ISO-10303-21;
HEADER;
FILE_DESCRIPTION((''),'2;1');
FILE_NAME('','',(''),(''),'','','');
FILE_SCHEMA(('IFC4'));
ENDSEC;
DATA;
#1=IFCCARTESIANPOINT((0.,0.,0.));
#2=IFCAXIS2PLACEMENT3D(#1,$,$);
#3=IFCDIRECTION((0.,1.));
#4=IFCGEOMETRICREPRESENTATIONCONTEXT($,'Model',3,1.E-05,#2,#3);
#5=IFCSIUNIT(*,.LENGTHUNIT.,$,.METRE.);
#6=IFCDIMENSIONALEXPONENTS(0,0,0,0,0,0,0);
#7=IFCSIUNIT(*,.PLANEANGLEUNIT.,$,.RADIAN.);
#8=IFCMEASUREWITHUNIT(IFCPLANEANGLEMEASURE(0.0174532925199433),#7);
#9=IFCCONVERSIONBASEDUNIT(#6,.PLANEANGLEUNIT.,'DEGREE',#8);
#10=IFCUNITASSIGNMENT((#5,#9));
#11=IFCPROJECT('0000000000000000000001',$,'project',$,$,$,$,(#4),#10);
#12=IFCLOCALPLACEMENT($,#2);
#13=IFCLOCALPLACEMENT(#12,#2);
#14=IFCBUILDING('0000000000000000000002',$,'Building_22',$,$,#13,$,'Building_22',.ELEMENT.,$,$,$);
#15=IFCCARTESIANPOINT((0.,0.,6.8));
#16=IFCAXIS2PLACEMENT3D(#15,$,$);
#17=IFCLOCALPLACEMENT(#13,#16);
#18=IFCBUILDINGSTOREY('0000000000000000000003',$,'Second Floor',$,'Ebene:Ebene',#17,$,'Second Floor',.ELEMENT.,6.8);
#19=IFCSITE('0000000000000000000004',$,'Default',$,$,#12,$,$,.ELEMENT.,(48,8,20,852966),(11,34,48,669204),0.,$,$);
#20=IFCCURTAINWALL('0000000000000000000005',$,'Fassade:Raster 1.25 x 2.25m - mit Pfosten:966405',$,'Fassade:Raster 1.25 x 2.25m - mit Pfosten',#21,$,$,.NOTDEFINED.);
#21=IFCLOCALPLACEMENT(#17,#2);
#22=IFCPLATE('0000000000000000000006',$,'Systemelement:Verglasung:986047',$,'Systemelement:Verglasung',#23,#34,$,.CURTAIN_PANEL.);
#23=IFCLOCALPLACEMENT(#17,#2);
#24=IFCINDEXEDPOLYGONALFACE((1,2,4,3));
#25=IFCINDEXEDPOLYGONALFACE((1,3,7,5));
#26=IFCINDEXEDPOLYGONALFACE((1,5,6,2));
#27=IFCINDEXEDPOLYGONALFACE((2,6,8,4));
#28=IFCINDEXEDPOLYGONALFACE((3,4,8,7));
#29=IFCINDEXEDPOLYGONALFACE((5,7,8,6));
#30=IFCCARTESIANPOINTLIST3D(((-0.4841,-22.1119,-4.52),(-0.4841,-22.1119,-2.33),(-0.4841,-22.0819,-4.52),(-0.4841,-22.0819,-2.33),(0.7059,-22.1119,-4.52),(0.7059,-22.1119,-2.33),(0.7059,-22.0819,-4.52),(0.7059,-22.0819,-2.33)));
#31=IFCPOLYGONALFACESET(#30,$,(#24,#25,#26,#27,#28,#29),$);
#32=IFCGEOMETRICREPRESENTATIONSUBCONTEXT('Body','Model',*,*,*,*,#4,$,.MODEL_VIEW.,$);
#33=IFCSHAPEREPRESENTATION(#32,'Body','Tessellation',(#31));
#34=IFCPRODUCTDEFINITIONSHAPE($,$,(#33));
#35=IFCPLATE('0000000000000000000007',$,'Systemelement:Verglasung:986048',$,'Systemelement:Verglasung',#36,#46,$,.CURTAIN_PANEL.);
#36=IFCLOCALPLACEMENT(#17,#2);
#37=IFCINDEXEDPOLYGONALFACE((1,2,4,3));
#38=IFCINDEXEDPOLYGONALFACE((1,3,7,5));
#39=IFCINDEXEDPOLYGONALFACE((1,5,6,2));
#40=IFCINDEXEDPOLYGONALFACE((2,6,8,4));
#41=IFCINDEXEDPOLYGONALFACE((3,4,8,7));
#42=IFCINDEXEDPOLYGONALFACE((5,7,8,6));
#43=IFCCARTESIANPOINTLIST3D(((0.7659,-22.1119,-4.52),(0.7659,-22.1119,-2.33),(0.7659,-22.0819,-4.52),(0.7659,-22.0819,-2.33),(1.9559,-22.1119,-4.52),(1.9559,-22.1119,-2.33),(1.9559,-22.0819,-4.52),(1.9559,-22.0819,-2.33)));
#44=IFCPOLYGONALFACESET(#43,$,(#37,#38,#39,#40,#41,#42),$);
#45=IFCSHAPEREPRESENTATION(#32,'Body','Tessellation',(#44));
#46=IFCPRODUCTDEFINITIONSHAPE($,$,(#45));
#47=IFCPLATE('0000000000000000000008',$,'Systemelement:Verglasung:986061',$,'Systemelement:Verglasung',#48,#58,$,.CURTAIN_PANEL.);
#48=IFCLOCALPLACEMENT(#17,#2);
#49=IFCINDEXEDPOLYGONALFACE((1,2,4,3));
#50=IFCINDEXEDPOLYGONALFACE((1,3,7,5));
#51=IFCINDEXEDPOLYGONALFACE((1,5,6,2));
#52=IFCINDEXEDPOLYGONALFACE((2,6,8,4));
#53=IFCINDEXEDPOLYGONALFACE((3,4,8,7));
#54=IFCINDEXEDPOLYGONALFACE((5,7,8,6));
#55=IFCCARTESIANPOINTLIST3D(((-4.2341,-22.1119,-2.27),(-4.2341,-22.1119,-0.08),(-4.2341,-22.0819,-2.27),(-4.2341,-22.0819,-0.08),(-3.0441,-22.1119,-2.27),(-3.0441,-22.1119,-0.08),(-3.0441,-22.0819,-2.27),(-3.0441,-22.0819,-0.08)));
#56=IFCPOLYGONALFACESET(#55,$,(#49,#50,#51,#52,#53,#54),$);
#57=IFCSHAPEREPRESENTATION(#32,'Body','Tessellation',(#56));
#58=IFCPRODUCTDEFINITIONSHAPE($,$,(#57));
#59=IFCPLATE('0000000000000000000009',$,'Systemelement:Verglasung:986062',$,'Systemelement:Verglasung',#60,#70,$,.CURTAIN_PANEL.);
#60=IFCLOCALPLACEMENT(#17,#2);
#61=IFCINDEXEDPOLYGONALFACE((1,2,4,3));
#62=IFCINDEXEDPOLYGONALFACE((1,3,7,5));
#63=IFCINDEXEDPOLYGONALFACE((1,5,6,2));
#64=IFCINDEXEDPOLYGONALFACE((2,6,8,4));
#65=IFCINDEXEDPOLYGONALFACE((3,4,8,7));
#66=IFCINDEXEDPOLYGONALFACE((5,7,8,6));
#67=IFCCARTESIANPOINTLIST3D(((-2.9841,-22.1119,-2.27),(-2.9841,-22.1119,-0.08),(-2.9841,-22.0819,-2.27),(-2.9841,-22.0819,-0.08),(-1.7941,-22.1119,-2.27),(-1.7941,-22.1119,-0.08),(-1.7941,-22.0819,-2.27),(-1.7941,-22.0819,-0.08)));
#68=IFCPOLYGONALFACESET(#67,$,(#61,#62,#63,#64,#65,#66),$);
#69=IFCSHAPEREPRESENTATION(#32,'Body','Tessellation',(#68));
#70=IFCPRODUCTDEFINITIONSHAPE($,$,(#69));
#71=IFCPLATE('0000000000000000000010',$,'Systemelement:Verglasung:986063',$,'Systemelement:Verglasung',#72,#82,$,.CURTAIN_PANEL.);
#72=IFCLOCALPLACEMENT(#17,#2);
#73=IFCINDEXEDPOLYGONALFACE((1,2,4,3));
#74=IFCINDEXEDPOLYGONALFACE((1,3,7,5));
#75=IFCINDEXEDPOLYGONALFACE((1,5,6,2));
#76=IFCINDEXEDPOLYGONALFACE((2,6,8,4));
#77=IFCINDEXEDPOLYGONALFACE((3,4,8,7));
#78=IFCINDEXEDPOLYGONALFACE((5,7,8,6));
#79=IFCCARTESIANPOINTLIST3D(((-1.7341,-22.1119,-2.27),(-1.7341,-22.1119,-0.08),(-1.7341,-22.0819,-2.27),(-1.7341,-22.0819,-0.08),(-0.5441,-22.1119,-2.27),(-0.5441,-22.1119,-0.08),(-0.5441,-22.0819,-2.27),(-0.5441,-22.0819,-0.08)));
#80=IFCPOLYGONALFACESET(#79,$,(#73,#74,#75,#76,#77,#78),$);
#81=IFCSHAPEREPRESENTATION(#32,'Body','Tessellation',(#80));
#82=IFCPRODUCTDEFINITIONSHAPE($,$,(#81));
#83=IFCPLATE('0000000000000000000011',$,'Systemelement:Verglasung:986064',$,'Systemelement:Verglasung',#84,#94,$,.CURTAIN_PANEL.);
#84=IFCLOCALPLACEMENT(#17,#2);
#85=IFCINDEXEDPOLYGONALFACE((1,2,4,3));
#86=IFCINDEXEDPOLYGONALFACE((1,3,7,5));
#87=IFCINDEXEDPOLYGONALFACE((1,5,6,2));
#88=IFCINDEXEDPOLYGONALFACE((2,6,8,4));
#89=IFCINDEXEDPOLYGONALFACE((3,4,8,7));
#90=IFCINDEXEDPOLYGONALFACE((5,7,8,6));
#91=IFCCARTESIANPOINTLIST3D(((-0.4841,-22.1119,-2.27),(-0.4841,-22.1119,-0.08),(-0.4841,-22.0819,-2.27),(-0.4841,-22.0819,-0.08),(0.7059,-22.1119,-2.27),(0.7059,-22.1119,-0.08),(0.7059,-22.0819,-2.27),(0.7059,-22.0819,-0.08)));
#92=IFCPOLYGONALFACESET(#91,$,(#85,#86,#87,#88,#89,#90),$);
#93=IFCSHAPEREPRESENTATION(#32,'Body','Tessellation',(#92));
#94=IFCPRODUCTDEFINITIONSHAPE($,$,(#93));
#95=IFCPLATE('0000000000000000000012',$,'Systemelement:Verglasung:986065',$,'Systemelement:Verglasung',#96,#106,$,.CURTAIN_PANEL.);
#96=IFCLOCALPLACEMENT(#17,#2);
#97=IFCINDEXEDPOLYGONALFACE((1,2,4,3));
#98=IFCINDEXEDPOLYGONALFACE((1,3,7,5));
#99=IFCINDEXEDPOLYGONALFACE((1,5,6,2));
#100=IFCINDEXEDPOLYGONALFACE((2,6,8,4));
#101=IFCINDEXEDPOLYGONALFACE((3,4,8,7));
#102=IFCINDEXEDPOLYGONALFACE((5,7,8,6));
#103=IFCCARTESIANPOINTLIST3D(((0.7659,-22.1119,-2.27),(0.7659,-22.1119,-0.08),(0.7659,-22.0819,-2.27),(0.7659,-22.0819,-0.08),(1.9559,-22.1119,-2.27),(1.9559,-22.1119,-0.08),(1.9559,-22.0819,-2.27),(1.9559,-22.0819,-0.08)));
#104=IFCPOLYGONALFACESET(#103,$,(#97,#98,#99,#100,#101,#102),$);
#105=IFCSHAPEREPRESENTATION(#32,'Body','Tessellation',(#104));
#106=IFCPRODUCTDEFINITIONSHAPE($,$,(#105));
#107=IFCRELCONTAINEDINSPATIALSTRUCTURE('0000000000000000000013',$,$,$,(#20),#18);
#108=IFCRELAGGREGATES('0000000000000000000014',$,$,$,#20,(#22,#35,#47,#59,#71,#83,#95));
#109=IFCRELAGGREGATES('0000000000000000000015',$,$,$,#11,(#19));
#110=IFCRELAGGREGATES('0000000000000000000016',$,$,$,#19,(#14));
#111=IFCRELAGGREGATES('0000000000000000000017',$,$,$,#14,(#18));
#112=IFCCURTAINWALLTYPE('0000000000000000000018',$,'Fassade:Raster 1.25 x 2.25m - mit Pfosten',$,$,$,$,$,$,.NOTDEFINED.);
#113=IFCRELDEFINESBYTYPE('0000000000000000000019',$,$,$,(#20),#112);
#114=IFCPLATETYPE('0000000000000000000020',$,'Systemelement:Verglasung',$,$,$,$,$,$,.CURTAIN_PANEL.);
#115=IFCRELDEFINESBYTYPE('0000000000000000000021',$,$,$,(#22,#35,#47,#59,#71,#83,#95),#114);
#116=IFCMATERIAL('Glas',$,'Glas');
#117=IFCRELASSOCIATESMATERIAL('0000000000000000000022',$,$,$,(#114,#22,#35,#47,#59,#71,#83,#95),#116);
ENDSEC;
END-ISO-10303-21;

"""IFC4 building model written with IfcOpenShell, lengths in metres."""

from ifc_helpers import new_model, entity, si_unit, converted_unit, direction, frame, origin, place, context, subcontext, project, spatial, indexed_curve, outline, extrude, source, transform, mapped, material, type_object, type_shapes, element, aggregate, save


model = new_model("IFC4")

# Units and contexts
model_context = context("Model", 3, precision=1e-05, world=origin(), true_north=direction((0.0, 1.0)))
body_context = subcontext(model_context, "Body", "Model", "MODEL_VIEW")
ifc_project = project(units=[si_unit("LENGTHUNIT", "METRE"), converted_unit("PLANEANGLEUNIT", "DEGREE", entity("IfcPlaneAngleMeasure", 0.0174532925199433), si_unit("PLANEANGLEUNIT", "RADIAN"), dimensions=[0, 0, 0, 0, 0, 0, 0])], contexts=[model_context])

# Site, building, storey
site_placement = place(None, origin())
site = spatial("IfcSite", under=ifc_project, at=site_placement, Name="Default", CompositionType="ELEMENT", RefLatitude=(48, 8, 20, 852966), RefLongitude=(11, 34, 48, 669204), RefElevation=0.0)
building_placement = place(site_placement, origin())
building = spatial("IfcBuilding", under=site, at=building_placement, Name="Building_22", LongName="Building_22", CompositionType="ELEMENT")
storey_placement = place(building_placement, frame((0.0, 0.0, 6.8)))
storey = spatial("IfcBuildingStorey", under=building, at=storey_placement, Name="Second Floor", ObjectType="Ebene:Ebene", LongName="Second Floor", CompositionType="ELEMENT", Elevation=6.8)

# Curtain wall, plates
curtain_wall_type = type_object("IfcCurtainWallType", Name="Fassade:Raster 1.25 x 2.25m - mit Pfosten", PredefinedType="NOTDEFINED")
curtain_wall_placement = place(storey_placement, frame((0.0, 0.0, -6.8)))
curtain_wall = element("IfcCurtainWall", 1, at=curtain_wall_placement, inside=storey, type_object=curtain_wall_type, Name="Fassade:Raster 1.25 x 2.25m - mit Pfosten:966405", ObjectType="Fassade:Raster 1.25 x 2.25m - mit Pfosten", PredefinedType="NOTDEFINED")
ifc_material_1 = material(Name="Glas", Category="Glas")
plate_type_1 = type_object("IfcPlateType", Name="Systemelement:Verglasung", PredefinedType="CURTAIN_PANEL", material=ifc_material_1)
shared_shape_1 = source(origin(), body_context, "Body", "SweptSolid", [
    extrude(outline(indexed_curve([(-0.015, -0.595), (0.015, -0.595), (0.015, 0.595), (-0.015, 0.595), (-0.015, -0.595)], self_intersect=False)), frame((0.0, 0.0, 0.0), z_axis=(0.0, 0.0, 1.0), x_axis=(0.0, 1.0, 0.0)), (0.0, 0.0, 1.0), 2.19),
])
type_shapes(plate_type_1, [shared_shape_1])
plate_1_placement = place(curtain_wall_placement, frame((0.1109, -22.0969, 2.28)))
plate_1 = element("IfcPlate", 2, at=plate_1_placement, type_object=plate_type_1, material=ifc_material_1, Name="Systemelement:Verglasung:986047", ObjectType="Systemelement:Verglasung", PredefinedType="CURTAIN_PANEL", context=body_context, shape_type="MappedRepresentation", body=[
    mapped(shared_shape_1, transform((0.0, 0.0, 0.0), scale=1.0)),
])
plate_2_placement = place(curtain_wall_placement, frame((1.3609, -22.0969, 2.28)))
plate_2 = element("IfcPlate", 3, at=plate_2_placement, type_object=plate_type_1, material=ifc_material_1, Name="Systemelement:Verglasung:986048", ObjectType="Systemelement:Verglasung", PredefinedType="CURTAIN_PANEL", context=body_context, shape_type="MappedRepresentation", body=[
    mapped(shared_shape_1, transform((0.0, 0.0, 0.0), scale=1.0)),
])
plate_3_placement = place(curtain_wall_placement, frame((-3.6391, -22.0969, 4.53)))
plate_3 = element("IfcPlate", 4, at=plate_3_placement, type_object=plate_type_1, material=ifc_material_1, Name="Systemelement:Verglasung:986061", ObjectType="Systemelement:Verglasung", PredefinedType="CURTAIN_PANEL", context=body_context, shape_type="MappedRepresentation", body=[
    mapped(shared_shape_1, transform((0.0, 0.0, 0.0), scale=1.0)),
])
plate_4_placement = place(curtain_wall_placement, frame((-2.3891, -22.0969, 4.53)))
plate_4 = element("IfcPlate", 5, at=plate_4_placement, type_object=plate_type_1, material=ifc_material_1, Name="Systemelement:Verglasung:986062", ObjectType="Systemelement:Verglasung", PredefinedType="CURTAIN_PANEL", context=body_context, shape_type="MappedRepresentation", body=[
    mapped(shared_shape_1, transform((0.0, 0.0, 0.0), scale=1.0)),
])
plate_5_placement = place(curtain_wall_placement, frame((-1.1391, -22.0969, 4.53)))
plate_5 = element("IfcPlate", 6, at=plate_5_placement, type_object=plate_type_1, material=ifc_material_1, Name="Systemelement:Verglasung:986063", ObjectType="Systemelement:Verglasung", PredefinedType="CURTAIN_PANEL", context=body_context, shape_type="MappedRepresentation", body=[
    mapped(shared_shape_1, transform((0.0, 0.0, 0.0), scale=1.0)),
])
plate_6_placement = place(curtain_wall_placement, frame((0.1109, -22.0969, 4.53)))
plate_6 = element("IfcPlate", 7, at=plate_6_placement, type_object=plate_type_1, material=ifc_material_1, Name="Systemelement:Verglasung:986064", ObjectType="Systemelement:Verglasung", PredefinedType="CURTAIN_PANEL", context=body_context, shape_type="MappedRepresentation", body=[
    mapped(shared_shape_1, transform((0.0, 0.0, 0.0), scale=1.0)),
])
plate_7_placement = place(curtain_wall_placement, frame((1.3609, -22.0969, 4.53)))
plate_7 = element("IfcPlate", 8, at=plate_7_placement, type_object=plate_type_1, material=ifc_material_1, Name="Systemelement:Verglasung:986065", ObjectType="Systemelement:Verglasung", PredefinedType="CURTAIN_PANEL", context=body_context, shape_type="MappedRepresentation", body=[
    mapped(shared_shape_1, transform((0.0, 0.0, 0.0), scale=1.0)),
])
aggregate(curtain_wall, [plate_1, plate_2, plate_3, plate_4, plate_5, plate_6, plate_7])

save(model, "model.ifc")
